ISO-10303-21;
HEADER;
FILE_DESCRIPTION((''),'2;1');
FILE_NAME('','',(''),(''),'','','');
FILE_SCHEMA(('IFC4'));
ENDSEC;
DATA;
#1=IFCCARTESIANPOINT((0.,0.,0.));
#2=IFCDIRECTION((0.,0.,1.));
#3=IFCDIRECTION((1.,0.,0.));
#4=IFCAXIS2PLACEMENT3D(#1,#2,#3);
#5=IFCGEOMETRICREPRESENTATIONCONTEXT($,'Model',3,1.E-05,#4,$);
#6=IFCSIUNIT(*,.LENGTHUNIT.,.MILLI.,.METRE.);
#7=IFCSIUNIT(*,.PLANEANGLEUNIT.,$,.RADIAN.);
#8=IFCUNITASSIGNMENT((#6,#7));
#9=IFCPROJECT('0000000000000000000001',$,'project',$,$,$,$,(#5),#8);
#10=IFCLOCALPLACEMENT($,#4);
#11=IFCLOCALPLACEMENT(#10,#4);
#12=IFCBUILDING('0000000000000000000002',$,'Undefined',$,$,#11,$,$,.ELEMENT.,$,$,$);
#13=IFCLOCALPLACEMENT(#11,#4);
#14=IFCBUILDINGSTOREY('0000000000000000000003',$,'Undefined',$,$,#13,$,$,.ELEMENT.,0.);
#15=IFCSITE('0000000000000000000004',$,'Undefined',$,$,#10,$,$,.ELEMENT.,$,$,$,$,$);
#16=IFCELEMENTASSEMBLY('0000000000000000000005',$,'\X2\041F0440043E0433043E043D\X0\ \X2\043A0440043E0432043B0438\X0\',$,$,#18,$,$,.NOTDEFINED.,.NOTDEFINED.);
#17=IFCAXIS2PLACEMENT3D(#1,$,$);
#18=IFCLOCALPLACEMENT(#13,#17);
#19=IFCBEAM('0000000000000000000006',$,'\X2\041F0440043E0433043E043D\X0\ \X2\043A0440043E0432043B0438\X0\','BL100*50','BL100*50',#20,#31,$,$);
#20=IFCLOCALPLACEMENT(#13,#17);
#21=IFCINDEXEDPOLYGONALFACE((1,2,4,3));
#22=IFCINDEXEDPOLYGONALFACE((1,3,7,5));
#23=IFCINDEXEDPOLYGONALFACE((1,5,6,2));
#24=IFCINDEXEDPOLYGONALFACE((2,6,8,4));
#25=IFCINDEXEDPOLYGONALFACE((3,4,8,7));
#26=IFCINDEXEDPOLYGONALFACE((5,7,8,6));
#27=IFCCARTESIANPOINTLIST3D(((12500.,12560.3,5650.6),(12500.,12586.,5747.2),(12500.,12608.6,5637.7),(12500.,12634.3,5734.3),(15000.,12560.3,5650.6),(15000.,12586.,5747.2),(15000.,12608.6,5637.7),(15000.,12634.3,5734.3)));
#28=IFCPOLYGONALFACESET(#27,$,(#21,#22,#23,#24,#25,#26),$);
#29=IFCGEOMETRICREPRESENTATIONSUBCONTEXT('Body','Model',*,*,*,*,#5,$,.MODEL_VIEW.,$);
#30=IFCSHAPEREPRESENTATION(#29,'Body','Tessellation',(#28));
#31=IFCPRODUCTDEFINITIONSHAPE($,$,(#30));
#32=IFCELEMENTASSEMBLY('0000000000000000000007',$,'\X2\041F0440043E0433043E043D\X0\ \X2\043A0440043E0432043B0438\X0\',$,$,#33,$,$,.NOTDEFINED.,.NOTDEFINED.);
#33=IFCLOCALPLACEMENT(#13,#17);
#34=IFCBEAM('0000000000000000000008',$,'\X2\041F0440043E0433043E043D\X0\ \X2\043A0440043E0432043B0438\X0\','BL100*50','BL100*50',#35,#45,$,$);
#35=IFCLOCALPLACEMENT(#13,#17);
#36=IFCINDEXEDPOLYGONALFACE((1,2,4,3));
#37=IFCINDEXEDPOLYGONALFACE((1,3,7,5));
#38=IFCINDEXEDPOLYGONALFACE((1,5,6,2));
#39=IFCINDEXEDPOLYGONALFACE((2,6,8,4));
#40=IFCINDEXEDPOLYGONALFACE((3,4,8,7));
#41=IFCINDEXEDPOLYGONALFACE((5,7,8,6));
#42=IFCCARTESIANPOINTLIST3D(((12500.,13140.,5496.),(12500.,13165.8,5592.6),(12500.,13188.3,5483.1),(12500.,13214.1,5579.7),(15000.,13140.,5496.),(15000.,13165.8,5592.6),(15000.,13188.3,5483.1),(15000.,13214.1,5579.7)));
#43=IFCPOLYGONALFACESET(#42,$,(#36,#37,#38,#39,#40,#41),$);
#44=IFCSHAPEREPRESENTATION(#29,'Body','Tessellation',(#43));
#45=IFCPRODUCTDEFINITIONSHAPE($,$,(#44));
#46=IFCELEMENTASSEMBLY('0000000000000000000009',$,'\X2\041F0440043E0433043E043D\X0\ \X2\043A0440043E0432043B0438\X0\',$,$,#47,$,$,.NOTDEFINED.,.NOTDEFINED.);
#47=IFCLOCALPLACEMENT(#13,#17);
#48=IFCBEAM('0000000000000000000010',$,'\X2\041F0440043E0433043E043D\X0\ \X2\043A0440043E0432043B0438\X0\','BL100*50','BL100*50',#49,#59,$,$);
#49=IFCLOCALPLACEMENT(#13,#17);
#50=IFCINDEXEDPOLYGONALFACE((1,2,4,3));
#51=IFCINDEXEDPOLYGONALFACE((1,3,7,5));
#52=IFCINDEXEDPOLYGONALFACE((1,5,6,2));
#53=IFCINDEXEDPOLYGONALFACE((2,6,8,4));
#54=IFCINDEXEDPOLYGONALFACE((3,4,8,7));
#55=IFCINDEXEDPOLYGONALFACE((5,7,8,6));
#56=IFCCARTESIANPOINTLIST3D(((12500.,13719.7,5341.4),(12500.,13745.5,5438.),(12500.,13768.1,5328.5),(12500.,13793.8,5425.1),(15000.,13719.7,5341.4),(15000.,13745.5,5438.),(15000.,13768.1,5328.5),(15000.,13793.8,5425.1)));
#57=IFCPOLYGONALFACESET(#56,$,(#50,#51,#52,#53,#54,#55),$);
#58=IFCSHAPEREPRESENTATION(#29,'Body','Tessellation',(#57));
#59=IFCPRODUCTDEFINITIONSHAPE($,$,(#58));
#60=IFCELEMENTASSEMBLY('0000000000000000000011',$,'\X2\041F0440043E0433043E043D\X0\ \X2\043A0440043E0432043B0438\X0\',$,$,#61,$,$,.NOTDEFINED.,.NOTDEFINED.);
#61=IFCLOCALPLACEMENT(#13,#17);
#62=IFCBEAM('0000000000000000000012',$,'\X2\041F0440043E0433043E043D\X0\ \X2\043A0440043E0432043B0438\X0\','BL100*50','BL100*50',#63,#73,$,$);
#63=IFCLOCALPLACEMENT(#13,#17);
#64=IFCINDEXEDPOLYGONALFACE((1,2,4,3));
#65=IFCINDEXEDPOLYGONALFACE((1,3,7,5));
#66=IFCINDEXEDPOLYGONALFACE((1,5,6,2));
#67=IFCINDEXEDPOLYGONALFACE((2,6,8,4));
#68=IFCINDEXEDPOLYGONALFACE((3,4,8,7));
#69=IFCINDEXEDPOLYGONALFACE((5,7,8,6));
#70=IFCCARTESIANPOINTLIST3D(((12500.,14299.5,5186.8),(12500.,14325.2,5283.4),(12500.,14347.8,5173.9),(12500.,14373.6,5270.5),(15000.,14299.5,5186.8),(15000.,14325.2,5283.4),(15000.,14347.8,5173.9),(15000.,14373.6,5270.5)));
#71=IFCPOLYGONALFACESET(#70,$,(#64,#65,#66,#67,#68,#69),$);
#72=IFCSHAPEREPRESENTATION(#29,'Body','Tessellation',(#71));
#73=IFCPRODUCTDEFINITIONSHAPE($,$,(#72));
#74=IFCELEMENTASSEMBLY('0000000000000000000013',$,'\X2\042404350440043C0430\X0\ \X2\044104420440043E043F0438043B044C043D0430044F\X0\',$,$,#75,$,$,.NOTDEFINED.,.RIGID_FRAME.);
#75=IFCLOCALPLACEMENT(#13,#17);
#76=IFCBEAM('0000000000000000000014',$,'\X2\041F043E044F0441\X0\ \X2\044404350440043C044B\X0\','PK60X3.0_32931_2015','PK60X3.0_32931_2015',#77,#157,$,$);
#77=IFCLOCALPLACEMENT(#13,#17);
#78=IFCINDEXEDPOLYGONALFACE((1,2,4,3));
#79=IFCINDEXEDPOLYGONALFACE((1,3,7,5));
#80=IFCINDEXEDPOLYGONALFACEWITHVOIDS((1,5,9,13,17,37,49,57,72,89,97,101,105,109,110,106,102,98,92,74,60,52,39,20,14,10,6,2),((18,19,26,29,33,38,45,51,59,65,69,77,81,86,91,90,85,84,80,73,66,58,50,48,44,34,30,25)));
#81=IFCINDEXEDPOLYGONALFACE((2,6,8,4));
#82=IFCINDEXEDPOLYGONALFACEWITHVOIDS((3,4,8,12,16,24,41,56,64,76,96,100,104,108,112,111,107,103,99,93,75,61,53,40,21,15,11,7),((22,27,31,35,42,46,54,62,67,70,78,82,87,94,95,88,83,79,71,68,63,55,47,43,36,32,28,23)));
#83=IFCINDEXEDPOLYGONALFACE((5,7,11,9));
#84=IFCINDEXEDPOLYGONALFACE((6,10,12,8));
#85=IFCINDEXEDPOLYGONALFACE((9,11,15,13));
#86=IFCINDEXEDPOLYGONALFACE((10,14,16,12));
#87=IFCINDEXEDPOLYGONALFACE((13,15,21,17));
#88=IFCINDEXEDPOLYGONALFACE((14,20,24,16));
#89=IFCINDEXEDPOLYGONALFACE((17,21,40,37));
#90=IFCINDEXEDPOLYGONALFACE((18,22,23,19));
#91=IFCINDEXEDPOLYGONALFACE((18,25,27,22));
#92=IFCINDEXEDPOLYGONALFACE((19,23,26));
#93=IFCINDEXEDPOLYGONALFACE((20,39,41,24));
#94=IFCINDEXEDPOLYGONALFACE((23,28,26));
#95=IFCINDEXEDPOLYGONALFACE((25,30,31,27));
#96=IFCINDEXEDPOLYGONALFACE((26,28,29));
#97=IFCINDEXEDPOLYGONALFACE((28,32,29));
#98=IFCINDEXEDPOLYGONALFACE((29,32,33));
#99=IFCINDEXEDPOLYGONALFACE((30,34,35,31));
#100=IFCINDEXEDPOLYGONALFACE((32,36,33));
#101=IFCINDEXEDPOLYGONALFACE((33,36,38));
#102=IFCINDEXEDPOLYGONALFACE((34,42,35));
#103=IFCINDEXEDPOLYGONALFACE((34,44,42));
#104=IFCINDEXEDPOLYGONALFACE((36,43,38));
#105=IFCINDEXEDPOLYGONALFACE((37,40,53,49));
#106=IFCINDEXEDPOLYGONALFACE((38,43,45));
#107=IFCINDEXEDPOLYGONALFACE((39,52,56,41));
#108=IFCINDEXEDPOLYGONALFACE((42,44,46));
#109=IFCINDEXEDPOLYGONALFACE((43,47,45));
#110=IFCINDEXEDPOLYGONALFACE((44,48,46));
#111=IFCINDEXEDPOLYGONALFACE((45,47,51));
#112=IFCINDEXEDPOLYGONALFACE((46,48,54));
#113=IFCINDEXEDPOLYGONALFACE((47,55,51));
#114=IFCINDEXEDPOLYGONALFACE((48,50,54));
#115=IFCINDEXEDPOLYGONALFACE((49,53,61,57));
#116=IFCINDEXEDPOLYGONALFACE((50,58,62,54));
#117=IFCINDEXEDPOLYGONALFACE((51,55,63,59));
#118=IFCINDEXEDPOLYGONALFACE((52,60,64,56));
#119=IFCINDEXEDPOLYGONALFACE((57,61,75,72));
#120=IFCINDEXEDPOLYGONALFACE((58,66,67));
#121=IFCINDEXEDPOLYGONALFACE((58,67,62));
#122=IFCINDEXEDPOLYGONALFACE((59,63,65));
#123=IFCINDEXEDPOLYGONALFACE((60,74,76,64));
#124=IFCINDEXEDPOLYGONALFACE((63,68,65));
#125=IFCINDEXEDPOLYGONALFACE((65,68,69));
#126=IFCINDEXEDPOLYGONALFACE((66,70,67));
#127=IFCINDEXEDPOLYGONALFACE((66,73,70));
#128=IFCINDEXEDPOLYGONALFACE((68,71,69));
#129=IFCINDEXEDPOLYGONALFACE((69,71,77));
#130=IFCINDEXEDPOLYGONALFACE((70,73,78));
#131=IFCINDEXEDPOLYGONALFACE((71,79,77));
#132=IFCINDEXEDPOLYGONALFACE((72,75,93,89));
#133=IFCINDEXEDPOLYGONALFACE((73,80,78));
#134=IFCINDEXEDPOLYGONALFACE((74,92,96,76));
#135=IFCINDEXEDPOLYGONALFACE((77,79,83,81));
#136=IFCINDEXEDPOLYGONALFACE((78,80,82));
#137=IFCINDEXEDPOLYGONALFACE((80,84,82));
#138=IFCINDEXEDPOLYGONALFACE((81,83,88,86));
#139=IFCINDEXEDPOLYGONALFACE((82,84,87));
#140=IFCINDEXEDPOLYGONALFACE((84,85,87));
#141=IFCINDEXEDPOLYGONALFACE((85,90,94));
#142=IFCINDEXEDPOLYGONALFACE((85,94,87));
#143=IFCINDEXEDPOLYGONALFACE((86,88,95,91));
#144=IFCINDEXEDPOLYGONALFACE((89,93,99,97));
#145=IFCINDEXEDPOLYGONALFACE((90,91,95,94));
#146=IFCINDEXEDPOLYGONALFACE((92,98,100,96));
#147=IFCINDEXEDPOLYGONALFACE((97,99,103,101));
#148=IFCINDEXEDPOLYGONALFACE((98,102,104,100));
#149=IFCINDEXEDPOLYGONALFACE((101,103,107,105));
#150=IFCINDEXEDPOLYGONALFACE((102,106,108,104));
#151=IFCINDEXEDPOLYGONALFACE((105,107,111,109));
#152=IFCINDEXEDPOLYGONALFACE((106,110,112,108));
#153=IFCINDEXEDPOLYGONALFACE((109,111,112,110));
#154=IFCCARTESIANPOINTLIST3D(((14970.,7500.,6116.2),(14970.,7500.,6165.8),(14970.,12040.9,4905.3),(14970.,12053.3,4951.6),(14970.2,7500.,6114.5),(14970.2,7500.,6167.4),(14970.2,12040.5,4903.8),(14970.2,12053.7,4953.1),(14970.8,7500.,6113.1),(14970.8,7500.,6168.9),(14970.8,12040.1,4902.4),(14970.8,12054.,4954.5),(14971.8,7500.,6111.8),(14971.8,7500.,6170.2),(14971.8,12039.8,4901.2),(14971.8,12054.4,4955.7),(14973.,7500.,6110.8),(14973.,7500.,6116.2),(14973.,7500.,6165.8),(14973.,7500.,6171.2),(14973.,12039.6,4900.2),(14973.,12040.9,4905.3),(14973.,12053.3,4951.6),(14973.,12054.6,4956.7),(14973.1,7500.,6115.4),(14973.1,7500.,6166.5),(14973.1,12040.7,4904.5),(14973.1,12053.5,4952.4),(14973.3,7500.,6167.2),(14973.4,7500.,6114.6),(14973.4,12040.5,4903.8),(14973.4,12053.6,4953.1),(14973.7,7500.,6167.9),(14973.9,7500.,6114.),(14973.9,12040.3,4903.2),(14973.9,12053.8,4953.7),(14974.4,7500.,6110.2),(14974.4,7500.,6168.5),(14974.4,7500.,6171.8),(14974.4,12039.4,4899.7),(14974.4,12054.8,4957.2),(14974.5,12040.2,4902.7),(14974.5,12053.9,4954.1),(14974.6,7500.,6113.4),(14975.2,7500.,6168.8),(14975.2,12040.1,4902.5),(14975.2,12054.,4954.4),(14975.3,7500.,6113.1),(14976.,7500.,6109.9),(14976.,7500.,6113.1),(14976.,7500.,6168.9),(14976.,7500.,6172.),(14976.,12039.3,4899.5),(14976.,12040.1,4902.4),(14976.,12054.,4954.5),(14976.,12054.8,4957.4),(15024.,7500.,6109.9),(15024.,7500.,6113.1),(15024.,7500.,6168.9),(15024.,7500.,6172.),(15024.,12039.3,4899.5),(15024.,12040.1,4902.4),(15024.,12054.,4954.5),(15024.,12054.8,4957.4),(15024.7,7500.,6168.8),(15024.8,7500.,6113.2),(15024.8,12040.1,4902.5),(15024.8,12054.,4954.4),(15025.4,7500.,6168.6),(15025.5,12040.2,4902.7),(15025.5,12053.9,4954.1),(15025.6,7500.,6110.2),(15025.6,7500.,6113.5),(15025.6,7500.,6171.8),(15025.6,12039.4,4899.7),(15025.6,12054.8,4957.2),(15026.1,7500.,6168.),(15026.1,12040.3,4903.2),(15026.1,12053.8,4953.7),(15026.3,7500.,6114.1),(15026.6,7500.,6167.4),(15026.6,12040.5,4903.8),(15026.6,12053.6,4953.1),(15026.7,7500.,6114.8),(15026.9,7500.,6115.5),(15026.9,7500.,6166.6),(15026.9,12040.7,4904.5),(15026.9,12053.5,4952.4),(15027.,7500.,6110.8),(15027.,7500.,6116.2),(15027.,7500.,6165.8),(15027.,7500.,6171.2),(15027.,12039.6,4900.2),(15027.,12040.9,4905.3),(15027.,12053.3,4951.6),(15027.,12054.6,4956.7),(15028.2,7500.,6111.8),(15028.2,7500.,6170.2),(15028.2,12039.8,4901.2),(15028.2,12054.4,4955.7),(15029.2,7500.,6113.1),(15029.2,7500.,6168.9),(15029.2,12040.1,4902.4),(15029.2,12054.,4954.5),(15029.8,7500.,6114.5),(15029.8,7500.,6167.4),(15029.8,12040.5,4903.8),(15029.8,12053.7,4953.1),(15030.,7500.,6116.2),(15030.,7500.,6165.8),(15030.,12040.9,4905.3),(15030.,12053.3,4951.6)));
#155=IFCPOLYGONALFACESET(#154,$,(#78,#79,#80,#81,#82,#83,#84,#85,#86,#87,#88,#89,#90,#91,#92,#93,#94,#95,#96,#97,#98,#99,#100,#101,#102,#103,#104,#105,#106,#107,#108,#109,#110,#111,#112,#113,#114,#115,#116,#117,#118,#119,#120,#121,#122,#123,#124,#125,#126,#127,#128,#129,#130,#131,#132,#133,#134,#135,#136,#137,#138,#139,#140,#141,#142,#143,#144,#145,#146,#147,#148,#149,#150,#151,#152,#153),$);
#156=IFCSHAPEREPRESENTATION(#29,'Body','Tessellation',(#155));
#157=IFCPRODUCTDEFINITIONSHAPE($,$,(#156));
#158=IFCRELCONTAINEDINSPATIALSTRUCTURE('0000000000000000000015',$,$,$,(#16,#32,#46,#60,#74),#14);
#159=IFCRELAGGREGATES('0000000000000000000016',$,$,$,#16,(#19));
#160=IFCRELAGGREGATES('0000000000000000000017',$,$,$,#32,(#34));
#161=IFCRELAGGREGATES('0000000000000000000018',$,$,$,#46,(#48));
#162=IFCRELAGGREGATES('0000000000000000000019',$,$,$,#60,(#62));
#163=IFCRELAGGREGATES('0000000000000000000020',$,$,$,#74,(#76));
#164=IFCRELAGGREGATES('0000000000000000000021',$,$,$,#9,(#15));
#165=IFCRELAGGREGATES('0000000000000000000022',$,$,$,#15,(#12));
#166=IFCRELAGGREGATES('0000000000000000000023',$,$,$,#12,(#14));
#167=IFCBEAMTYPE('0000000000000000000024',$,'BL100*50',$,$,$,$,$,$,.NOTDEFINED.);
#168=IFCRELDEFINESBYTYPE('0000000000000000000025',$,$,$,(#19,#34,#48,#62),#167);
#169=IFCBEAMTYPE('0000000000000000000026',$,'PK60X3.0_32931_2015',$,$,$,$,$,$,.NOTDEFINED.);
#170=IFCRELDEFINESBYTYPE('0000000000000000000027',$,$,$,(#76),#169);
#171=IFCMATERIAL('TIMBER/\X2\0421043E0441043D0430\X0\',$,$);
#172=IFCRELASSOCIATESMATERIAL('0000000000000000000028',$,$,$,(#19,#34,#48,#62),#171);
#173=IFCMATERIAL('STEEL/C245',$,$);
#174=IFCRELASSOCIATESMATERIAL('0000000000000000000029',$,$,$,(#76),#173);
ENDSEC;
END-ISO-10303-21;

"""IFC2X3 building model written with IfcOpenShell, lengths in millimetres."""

from ifc_helpers import new_model, si_unit, frame, origin_with_axes, origin_2d_with_axis, place, context, subcontext, project, spatial, rectangle, hollow_rectangle, extrude, clip, halfspace, material, type_object, element, aggregate, save


model = new_model("IFC2X3")

# Units and contexts
model_context = context("Model", 3, precision=1e-05, world=origin_with_axes())
body_context = subcontext(model_context, "Body", "Model", "MODEL_VIEW")
ifc_project = project(units=[si_unit("LENGTHUNIT", "METRE", prefix="MILLI"), si_unit("PLANEANGLEUNIT", "RADIAN")], contexts=[model_context])

# Site, building, storey
site_placement = place(None, origin_with_axes())
site = spatial("IfcSite", under=ifc_project, at=site_placement, Name="Undefined", CompositionType="ELEMENT")
building_placement = place(site_placement, origin_with_axes())
building = spatial("IfcBuilding", under=site, at=building_placement, Name="Undefined", CompositionType="ELEMENT")
storey_placement = place(building_placement, origin_with_axes())
storey = spatial("IfcBuildingStorey", under=building, at=storey_placement, Name="Undefined", CompositionType="ELEMENT", Elevation=0.0)

# Shared definitions
ifc_material_1 = material(Name="STEEL/C245")

# Element assemblies, beams
assembly_1_placement = place(storey_placement, origin_with_axes())
assembly_1 = element("IfcElementAssembly", 1, at=assembly_1_placement, inside=storey, Name="Прогон кровли", AssemblyPlace="NOTDEFINED", PredefinedType="NOTDEFINED")
ifc_material_2 = material(Name="TIMBER/Сосна")
beam_type_1 = type_object("IfcBeamType", Name="BL100*50", PredefinedType="NOTDEFINED")
beam_1_placement = place(assembly_1_placement, frame((12500.0, 12597.3, 5692.5), z_axis=(0.0, -0.257663, -0.966235), x_axis=(1.0, 0.0, 0.0)))
beam_1 = element("IfcBeam", 2, at=beam_1_placement, type_object=beam_type_1, material=ifc_material_2, Name="Прогон кровли", Description="BL100*50", ObjectType="BL100*50", context=body_context, shape_type="SweptSolid", body=[
    extrude(rectangle(XDim=50.0, YDim=100.0, at=origin_2d_with_axis()), frame((2500.0, 0.0, 0.0), z_axis=(-1.0, 0.0, 0.0), x_axis=(0.0, -1.0, 0.0)), (0.0, 0.0, 1.0), 2500.0),
])
aggregate(assembly_1, [beam_1])
assembly_2_placement = place(storey_placement, origin_with_axes())
assembly_2 = element("IfcElementAssembly", 3, at=assembly_2_placement, inside=storey, Name="Прогон кровли", AssemblyPlace="NOTDEFINED", PredefinedType="NOTDEFINED")
beam_2_placement = place(assembly_2_placement, frame((12500.0, 13177.0, 5537.9), z_axis=(0.0, -0.257663, -0.966235), x_axis=(1.0, 0.0, 0.0)))
beam_2 = element("IfcBeam", 4, at=beam_2_placement, type_object=beam_type_1, material=ifc_material_2, Name="Прогон кровли", Description="BL100*50", ObjectType="BL100*50", context=body_context, shape_type="SweptSolid", body=[
    extrude(rectangle(XDim=50.0, YDim=100.0, at=origin_2d_with_axis()), frame((2500.0, 0.0, 0.0), z_axis=(-1.0, 0.0, 0.0), x_axis=(0.0, -1.0, 0.0)), (0.0, 0.0, 1.0), 2500.0),
])
aggregate(assembly_2, [beam_2])
assembly_3_placement = place(storey_placement, origin_with_axes())
assembly_3 = element("IfcElementAssembly", 5, at=assembly_3_placement, inside=storey, Name="Прогон кровли", AssemblyPlace="NOTDEFINED", PredefinedType="NOTDEFINED")
beam_3_placement = place(assembly_3_placement, frame((12500.0, 13756.8, 5383.3), z_axis=(0.0, -0.257663, -0.966235), x_axis=(1.0, 0.0, 0.0)))
beam_3 = element("IfcBeam", 6, at=beam_3_placement, type_object=beam_type_1, material=ifc_material_2, Name="Прогон кровли", Description="BL100*50", ObjectType="BL100*50", context=body_context, shape_type="SweptSolid", body=[
    extrude(rectangle(XDim=50.0, YDim=100.0, at=origin_2d_with_axis()), frame((2500.0, 0.0, 0.0), z_axis=(-1.0, 0.0, 0.0), x_axis=(0.0, -1.0, 0.0)), (0.0, 0.0, 1.0), 2500.0),
])
aggregate(assembly_3, [beam_3])
assembly_4_placement = place(storey_placement, origin_with_axes())
assembly_4 = element("IfcElementAssembly", 7, at=assembly_4_placement, inside=storey, Name="Прогон кровли", AssemblyPlace="NOTDEFINED", PredefinedType="NOTDEFINED")
beam_4_placement = place(assembly_4_placement, frame((12500.0, 14336.5, 5228.7), z_axis=(0.0, -0.257663, -0.966235), x_axis=(1.0, 0.0, 0.0)))
beam_4 = element("IfcBeam", 8, at=beam_4_placement, type_object=beam_type_1, material=ifc_material_2, Name="Прогон кровли", Description="BL100*50", ObjectType="BL100*50", context=body_context, shape_type="SweptSolid", body=[
    extrude(rectangle(XDim=50.0, YDim=100.0, at=origin_2d_with_axis()), frame((2500.0, 0.0, 0.0), z_axis=(-1.0, 0.0, 0.0), x_axis=(0.0, -1.0, 0.0)), (0.0, 0.0, 1.0), 2500.0),
])
aggregate(assembly_4, [beam_4])

# Element assembly, beam
assembly_5_placement = place(storey_placement, origin_with_axes())
assembly_5 = element("IfcElementAssembly", 9, at=assembly_5_placement, inside=storey, Name="Ферма стропильная", AssemblyPlace="NOTDEFINED", PredefinedType="RIGID_FRAME")
beam_type_2 = type_object("IfcBeamType", Name="PK60X3.0_32931_2015", PredefinedType="NOTDEFINED")
beam_5_placement = place(assembly_5_placement, frame((15000.0, 12047.1, 4928.4), z_axis=(0.0, 0.257663, 0.966235), x_axis=(0.0, -0.966235, 0.257663)))
beam_5 = element("IfcBeam", 10, at=beam_5_placement, type_object=beam_type_2, material=ifc_material_1, Name="Пояс фермы", Description="PK60X3.0_32931_2015", ObjectType="PK60X3.0_32931_2015", context=body_context, shape_type="Clipping", body=[
    clip(extrude(hollow_rectangle(XDim=60.0, YDim=60.0, WallThickness=3.0, InnerFilletRadius=3.0, OuterFilletRadius=6.0, at=origin_2d_with_axis()), frame((4729.1, 0.0, 0.0), z_axis=(-1.0, 0.0, 0.0), x_axis=(0.0, -1.0, 0.0)), (0.0, 0.0, 1.0), 4729.1), halfspace(frame((4938.1, 0.0, 870.5), z_axis=(0.966235, 0.0, -0.257663), x_axis=(0.257663, 0.0, 0.966235)), False)),
])

aggregate(assembly_5, [beam_5])

save(model, "model.ifc")
